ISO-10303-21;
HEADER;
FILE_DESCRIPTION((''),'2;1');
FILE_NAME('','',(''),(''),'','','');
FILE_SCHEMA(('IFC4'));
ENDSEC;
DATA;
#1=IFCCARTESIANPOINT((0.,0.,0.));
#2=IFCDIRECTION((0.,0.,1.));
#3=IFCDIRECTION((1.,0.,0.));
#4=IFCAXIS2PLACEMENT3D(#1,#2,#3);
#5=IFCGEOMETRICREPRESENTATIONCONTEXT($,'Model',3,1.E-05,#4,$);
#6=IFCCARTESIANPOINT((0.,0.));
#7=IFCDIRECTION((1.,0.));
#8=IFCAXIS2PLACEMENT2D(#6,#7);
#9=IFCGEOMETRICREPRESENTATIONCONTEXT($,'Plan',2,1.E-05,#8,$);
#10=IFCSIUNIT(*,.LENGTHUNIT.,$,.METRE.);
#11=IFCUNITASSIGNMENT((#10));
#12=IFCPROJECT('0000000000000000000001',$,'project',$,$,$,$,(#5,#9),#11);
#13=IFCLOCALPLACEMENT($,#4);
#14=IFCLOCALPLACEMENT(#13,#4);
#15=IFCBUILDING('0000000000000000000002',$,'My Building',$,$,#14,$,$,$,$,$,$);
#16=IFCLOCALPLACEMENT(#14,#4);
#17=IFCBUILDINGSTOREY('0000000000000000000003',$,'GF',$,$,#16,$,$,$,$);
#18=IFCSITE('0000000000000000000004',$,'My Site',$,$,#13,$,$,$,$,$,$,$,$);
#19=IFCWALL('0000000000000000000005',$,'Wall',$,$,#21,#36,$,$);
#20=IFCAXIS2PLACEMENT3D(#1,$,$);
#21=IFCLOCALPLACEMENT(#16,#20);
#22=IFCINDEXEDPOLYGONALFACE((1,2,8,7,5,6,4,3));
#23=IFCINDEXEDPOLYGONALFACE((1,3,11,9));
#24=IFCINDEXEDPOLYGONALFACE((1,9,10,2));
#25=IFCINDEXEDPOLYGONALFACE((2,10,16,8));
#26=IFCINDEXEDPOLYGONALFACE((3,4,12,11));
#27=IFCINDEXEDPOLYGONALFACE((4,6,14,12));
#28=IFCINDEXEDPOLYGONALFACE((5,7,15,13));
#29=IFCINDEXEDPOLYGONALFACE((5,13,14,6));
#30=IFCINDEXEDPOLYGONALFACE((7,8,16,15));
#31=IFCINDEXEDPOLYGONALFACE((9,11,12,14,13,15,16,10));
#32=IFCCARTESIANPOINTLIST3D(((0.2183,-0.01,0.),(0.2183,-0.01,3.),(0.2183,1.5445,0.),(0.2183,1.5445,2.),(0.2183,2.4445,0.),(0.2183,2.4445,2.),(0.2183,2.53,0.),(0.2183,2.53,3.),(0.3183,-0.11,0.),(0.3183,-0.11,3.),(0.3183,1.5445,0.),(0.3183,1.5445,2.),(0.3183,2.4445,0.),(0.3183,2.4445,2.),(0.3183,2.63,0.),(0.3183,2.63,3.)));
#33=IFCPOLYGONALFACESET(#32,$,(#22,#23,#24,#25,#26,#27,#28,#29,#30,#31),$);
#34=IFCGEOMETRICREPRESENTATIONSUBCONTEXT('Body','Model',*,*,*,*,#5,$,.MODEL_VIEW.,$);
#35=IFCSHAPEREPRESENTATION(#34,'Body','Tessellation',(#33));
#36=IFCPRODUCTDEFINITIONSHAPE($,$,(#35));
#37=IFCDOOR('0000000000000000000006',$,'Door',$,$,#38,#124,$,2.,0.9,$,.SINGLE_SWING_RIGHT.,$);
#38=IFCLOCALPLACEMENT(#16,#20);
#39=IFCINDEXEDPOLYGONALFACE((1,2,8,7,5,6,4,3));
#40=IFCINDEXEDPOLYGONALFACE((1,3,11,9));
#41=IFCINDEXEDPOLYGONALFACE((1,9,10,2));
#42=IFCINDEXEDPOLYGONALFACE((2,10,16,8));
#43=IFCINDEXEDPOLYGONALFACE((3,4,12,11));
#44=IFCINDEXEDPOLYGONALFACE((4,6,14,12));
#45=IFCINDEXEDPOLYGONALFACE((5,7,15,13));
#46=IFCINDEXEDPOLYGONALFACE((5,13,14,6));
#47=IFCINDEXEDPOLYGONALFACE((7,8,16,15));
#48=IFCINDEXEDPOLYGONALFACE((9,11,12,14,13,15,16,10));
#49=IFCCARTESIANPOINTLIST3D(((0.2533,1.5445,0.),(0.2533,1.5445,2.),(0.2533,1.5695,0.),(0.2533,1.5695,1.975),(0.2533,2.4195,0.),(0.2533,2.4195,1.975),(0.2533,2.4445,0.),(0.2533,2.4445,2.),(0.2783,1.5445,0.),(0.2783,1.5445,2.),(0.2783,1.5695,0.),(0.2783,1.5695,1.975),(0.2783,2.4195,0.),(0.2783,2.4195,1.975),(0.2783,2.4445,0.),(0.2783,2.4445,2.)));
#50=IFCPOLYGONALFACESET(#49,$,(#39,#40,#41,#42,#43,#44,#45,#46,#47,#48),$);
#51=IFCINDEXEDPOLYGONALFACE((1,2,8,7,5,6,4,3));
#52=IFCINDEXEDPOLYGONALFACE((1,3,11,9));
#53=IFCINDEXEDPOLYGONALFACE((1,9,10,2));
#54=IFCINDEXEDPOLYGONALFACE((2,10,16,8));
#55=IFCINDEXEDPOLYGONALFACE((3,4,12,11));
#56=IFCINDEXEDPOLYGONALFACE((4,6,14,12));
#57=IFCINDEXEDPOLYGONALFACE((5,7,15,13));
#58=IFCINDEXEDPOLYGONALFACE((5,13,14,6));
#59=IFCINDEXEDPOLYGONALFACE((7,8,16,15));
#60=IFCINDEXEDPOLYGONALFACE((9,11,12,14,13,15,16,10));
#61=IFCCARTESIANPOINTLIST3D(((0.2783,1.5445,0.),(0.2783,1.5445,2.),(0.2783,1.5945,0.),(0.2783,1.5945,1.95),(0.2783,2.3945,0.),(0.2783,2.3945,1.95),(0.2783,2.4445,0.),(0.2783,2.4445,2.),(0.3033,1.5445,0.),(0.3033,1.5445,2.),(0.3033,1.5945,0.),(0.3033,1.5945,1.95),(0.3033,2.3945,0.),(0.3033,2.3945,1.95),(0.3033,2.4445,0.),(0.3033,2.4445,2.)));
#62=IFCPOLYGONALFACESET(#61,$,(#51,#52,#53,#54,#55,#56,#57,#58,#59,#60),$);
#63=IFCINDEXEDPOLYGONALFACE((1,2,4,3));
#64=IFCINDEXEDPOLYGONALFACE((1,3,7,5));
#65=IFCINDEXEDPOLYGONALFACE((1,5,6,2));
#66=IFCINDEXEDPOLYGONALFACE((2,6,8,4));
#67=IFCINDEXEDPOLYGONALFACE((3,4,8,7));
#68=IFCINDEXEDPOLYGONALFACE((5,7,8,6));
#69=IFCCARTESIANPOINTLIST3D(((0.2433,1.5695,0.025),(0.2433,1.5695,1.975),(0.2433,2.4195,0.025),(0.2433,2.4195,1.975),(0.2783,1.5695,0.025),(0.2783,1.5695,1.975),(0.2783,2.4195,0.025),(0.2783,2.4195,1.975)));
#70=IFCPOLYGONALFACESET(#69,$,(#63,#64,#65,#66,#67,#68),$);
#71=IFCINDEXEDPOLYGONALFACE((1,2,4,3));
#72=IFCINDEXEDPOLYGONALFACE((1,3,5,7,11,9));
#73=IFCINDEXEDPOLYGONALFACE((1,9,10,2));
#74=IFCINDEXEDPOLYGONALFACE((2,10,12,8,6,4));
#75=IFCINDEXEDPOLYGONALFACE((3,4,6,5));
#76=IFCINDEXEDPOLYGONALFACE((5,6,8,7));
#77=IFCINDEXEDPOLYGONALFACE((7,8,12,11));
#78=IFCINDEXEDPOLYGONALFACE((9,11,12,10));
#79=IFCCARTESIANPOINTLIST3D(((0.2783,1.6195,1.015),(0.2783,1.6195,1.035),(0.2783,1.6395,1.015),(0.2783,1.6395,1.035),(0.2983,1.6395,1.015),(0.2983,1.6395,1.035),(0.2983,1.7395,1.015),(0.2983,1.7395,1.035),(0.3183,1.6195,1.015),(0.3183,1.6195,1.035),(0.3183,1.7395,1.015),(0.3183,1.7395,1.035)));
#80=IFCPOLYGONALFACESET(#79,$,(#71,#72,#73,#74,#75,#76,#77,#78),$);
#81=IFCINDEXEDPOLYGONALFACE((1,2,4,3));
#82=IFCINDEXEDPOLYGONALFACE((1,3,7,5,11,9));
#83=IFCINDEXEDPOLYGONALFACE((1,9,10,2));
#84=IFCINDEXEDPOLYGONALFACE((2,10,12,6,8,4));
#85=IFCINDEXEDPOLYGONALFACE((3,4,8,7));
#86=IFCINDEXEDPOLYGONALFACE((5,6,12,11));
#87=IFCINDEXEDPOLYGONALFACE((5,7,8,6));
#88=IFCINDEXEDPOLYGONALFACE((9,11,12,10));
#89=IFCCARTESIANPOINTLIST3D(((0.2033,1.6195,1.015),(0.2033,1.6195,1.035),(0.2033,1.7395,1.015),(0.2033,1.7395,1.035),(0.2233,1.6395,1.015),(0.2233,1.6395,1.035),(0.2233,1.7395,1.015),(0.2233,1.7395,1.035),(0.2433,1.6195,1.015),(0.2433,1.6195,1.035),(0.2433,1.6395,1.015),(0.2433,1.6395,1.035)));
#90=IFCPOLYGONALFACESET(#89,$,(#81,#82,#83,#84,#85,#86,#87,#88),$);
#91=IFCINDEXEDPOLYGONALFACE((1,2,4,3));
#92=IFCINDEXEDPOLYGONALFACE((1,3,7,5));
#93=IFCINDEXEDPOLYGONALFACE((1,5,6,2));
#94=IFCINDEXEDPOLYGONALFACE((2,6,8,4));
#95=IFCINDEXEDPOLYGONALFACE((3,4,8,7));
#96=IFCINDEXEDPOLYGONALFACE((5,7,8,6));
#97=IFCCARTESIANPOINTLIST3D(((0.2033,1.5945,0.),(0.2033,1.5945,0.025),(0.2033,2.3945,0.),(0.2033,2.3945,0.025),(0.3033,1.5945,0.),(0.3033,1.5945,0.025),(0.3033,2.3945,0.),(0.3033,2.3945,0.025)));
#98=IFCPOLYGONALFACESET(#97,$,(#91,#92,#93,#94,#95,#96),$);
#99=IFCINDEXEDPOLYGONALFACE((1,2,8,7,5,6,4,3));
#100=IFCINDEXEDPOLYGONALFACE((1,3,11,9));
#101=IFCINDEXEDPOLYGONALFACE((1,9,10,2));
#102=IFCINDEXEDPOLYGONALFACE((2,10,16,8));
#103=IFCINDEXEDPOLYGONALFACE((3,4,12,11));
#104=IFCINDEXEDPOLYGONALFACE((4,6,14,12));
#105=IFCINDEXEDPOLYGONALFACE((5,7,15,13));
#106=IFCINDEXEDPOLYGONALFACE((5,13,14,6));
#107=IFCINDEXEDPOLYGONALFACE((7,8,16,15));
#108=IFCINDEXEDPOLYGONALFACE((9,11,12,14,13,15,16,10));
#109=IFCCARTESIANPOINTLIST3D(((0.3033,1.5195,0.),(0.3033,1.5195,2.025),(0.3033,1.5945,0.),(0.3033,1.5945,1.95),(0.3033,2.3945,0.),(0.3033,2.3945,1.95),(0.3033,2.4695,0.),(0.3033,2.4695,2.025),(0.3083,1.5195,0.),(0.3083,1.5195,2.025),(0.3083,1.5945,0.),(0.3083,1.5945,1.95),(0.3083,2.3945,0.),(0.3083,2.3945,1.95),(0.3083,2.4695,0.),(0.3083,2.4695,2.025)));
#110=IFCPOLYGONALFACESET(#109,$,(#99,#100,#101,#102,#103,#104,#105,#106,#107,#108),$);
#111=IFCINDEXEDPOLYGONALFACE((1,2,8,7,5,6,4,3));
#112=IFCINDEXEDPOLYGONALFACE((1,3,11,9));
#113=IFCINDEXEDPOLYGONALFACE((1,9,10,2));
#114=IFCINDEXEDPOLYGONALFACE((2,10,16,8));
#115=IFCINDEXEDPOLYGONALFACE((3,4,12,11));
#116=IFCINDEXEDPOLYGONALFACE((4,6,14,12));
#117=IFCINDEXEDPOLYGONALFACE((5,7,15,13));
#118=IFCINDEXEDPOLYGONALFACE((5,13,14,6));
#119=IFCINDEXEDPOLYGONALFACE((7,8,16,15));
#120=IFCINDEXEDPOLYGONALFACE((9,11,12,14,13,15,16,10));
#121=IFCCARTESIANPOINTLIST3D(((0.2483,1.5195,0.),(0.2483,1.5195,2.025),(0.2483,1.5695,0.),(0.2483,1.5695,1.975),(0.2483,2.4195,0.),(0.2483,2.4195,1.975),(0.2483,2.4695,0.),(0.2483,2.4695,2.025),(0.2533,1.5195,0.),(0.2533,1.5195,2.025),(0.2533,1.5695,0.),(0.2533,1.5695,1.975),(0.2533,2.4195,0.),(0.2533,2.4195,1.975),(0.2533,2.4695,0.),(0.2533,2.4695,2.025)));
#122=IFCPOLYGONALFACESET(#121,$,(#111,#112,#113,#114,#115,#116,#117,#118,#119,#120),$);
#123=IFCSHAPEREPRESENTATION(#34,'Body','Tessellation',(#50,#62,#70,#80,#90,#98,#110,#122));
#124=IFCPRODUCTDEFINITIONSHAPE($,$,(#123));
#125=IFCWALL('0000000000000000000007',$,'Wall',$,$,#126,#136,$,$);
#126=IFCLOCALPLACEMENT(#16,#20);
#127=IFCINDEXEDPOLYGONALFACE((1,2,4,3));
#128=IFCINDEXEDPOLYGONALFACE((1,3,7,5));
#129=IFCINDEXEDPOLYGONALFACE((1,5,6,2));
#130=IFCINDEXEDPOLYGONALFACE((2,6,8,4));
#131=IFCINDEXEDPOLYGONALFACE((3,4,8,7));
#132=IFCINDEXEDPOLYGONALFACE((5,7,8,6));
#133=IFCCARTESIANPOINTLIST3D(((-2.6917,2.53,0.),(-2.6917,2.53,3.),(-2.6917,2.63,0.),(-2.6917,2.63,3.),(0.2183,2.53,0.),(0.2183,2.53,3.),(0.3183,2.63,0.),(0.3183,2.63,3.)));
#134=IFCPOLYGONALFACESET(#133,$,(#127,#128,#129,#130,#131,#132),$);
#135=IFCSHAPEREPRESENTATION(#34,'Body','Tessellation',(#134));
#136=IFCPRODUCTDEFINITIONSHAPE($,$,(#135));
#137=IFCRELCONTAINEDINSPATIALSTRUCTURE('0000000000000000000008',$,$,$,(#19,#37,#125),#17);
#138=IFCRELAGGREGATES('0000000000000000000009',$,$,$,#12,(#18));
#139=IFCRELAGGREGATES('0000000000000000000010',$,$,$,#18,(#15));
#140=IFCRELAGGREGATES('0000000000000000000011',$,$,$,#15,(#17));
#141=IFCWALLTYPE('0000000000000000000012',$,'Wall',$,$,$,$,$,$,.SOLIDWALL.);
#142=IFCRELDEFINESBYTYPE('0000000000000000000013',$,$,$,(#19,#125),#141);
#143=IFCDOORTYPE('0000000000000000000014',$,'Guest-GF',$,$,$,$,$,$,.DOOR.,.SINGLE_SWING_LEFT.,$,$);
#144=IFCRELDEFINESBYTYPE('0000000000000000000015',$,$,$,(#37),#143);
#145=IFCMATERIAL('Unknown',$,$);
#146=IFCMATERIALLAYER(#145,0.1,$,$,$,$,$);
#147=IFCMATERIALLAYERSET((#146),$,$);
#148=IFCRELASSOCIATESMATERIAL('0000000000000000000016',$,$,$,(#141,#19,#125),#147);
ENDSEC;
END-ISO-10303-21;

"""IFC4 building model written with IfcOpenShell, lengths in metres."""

from ifc_helpers import new_model, entity, si_unit, frame, origin_with_axes, origin_2d_with_axis, place, context, subcontext, project, spatial, line, indexed_curve, outline, extrude, shape, source, transform, mapped, material, layer, layer_set, layer_usage, type_object, type_shapes, element, fill, save


model = new_model("IFC4")

# Units and contexts
model_context_1 = context("Model", 3, precision=1e-05, world=origin_with_axes())
plan_context = context("Plan", 2, precision=1e-05, world=origin_2d_with_axis())
body_context_1 = subcontext(model_context_1, "Body", "Model", "MODEL_VIEW")
body_context_2 = subcontext(plan_context, "Body", "Plan", "PLAN_VIEW")
ifc_project = project(units=[si_unit("LENGTHUNIT", "METRE")], contexts=[model_context_1, plan_context])

# Site, building, storey
site_placement = place(None, origin_with_axes())
site = spatial("IfcSite", under=ifc_project, at=site_placement, Name="My Site")
building_placement = place(site_placement, origin_with_axes())
building = spatial("IfcBuilding", under=site, at=building_placement, Name="My Building")
storey_placement = place(building_placement, origin_with_axes())
storey = spatial("IfcBuildingStorey", under=building, at=storey_placement, Name="GF")

# Shared definitions
ifc_material_1 = material(Name="Unknown")

# Shared definitions
ifc_layer_1 = layer(ifc_material_1, 0.1)
ifc_layer_set_1 = layer_set([ifc_layer_1])
wall_type = type_object("IfcWallType", Name="Wall", PredefinedType="SOLIDWALL", material=ifc_layer_set_1)

# Wall, opening, door
ifc_layer_usage_1 = layer_usage(ifc_layer_set_1, "AXIS2", "POSITIVE", 0.0)
wall_1_placement = place(storey_placement, frame((0.3183, -0.11, 0.0), z_axis=(0.0, 0.0, 1.0), x_axis=(0.0, 1.0, 0.0)))
wall_1 = element("IfcWall", 1, at=wall_1_placement, inside=storey, type_object=wall_type, material=ifc_layer_usage_1, Name="Wall", context=body_context_1, shape_type="SweptSolid", body=[
    extrude(outline(indexed_curve([(0.0, 0.0), (0.1, 0.1), (2.64, 0.1), (2.74, 0.0)], segments=[line(1, 2, 3, 4, 1)])), origin_with_axes(), (0.0, 0.0, 1.0), 3.0),
])
shared_shape_1 = source(origin_with_axes(), body_context_1, "Body", "SweptSolid", [
    extrude(outline(indexed_curve([(0.0, 0.0), (0.9, 0.0), (0.9, 2.0), (0.0, 2.0)], segments=[line(1, 2, 3, 4, 1)])), frame((0.0, -0.6, 0.0), z_axis=(0.0, -1.0, 0.0), x_axis=(1.0, 0.0, 0.0)), (0.0, 0.0, -1.0), 1.2),
])
opening_1_placement = place(wall_1_placement, frame((1.6545, 0.015, 0.0), z_axis=(0.0, 0.0, 1.0), x_axis=(1.0, 0.0, 0.0)))
opening_1 = element("IfcOpeningElement", 2, at=opening_1_placement, cuts=wall_1, PredefinedType="OPENING", context=body_context_1, shape_type="MappedRepresentation", body=[
    mapped(shared_shape_1, transform((0.0, 0.0, 0.0), x_axis=(1.0, 0.0, 0.0), y_axis=(0.0, 1.0, 0.0), z_axis=(0.0, 0.0, 1.0), scale=1.0)),
])
door_type_1 = type_object("IfcDoorType", Name="Guest-GF", OperationType="SINGLE_SWING_LEFT", PredefinedType="DOOR")
shared_shape_2 = source(origin_with_axes(), body_context_1, "Body", "SweptSolid", [
    extrude(outline(indexed_curve([(0.0, 0.0), (0.0, 2.0), (0.9, 2.0), (0.9, 0.0), (0.875, 0.0), (0.875, 1.975), (0.025, 1.975), (0.025, 0.0)], segments=[line(1, 2, 3, 4, 5, 6, 7, 8, 1)])), frame((0.0, 0.025, 0.0), z_axis=(0.0, -1.0, 0.0), x_axis=(1.0, 0.0, 0.0)), (0.0, 0.0, -1.0), 0.025),
    extrude(outline(indexed_curve([(0.0, 0.0), (0.0, 2.0), (0.9, 2.0), (0.9, 0.0), (0.85, 0.0), (0.85, 1.95), (0.05, 1.95), (0.05, 0.0)], segments=[line(1, 2, 3, 4, 5, 6, 7, 8, 1)])), frame((0.0, 0.0, 0.0), z_axis=(0.0, -1.0, 0.0), x_axis=(1.0, 0.0, 0.0)), (0.0, 0.0, -1.0), 0.025),
    extrude(outline(indexed_curve([(0.0, 0.0), (0.85, 0.0), (0.85, 0.035), (0.0, 0.035)], segments=[line(1, 2, 3, 4, 1)])), frame((0.025, 0.025, 0.025), z_axis=(0.0, 0.0, 1.0), x_axis=(1.0, 0.0, 0.0)), (0.0, 0.0, 1.0), 1.95),
    extrude(outline(indexed_curve([(0.0, 0.0), (0.0, -0.04), (0.12, -0.04), (0.12, -0.02), (0.02, -0.02), (0.02, 0.0)], segments=[line(1, 2, 3, 4, 5, 6, 1)])), frame((0.075, 0.025, 1.015), z_axis=(0.0, 0.0, 1.0), x_axis=(1.0, 0.0, 0.0)), (0.0, 0.0, 1.0), 0.02),
    extrude(outline(indexed_curve([(0.0, 0.0), (0.0, 0.04), (0.12, 0.04), (0.12, 0.02), (0.02, 0.02), (0.02, 0.0)], segments=[line(1, 2, 3, 4, 5, 6, 1)])), frame((0.075, 0.06, 1.015), z_axis=(0.0, 0.0, 1.0), x_axis=(1.0, 0.0, 0.0)), (0.0, 0.0, 1.0), 0.02),
    extrude(outline(indexed_curve([(0.0, 0.0), (0.8, 0.0), (0.8, 0.1), (0.0, 0.1)], segments=[line(1, 2, 3, 4, 1)])), frame((0.05, 0.0, 0.0), z_axis=(0.0, 0.0, 1.0), x_axis=(1.0, 0.0, 0.0)), (0.0, 0.0, 1.0), 0.025),
    extrude(outline(indexed_curve([(0.0, 0.0), (0.0, 2.025), (0.95, 2.025), (0.95, 0.0), (0.875, 0.0), (0.875, 1.95), (0.075, 1.95), (0.075, 0.0)], segments=[line(1, 2, 3, 4, 5, 6, 7, 8, 1)])), frame((-0.025, -0.005, 0.0), z_axis=(0.0, -1.0, 0.0), x_axis=(1.0, 0.0, 0.0)), (0.0, 0.0, -1.0), 0.005),
    extrude(outline(indexed_curve([(0.0, 0.0), (0.0, 2.025), (0.95, 2.025), (0.95, 0.0), (0.9, 0.0), (0.9, 1.975), (0.05, 1.975), (0.05, 0.0)], segments=[line(1, 2, 3, 4, 5, 6, 7, 8, 1)])), frame((-0.025, 0.05, 0.0), z_axis=(0.0, -1.0, 0.0), x_axis=(1.0, 0.0, 0.0)), (0.0, 0.0, -1.0), 0.005),
])
shared_shape_3 = source(origin_with_axes(), body_context_2, "Body", "Curve2D", [
    entity("IfcIndexedPolyCurve", entity("IfcCartesianPointList2D", [[0.0, 0.0], [0.0, 0.05], [0.025, 0.05], [0.025, 0.025], [0.05, 0.025], [0.05, 0.0]]), [entity("IfcLineIndex", [1, 2, 3, 4, 5, 6, 1])]),
    entity("IfcIndexedPolyCurve", entity("IfcCartesianPointList2D", [[0.9, 0.0], [0.9, 0.05], [0.875, 0.05], [0.875, 0.025], [0.85, 0.025], [0.85, 0.0]]), [entity("IfcLineIndex", [1, 2, 3, 4, 5, 6, 1])]),
    entity("IfcTrimmedCurve", entity("IfcEllipse", entity("IfcAxis2Placement2D", entity("IfcCartesianPoint", [0.84, 0.05]), entity("IfcDirection", [1.0, 0.0])), 0.815, 0.85), [entity("IfcCartesianPoint", [0.84, 0.9])], [entity("IfcCartesianPoint", [0.025, 0.05])], True, "CARTESIAN"),
    entity("IfcIndexedPolyCurve", entity("IfcCartesianPointList2D", [[0.875, 0.05], [0.84, 0.05], [0.84, 0.9], [0.875, 0.9]]), [entity("IfcLineIndex", [1, 2, 3, 4, 1])]),
])
type_shapes(door_type_1, [shared_shape_2, shared_shape_3])
door_1_placement = place(opening_1_placement, frame((0.0, 0.0, 0.0), z_axis=(0.0, 0.0, 1.0), x_axis=(1.0, 0.0, 0.0)))
door_1 = element("IfcDoor", 3, at=door_1_placement, inside=storey, type_object=door_type_1, Name="Door", OperationType="SINGLE_SWING_RIGHT", OverallHeight=2.0, OverallWidth=0.9, shapes=[
    shape(body_context_1, "Body", "MappedRepresentation", [mapped(shared_shape_2, transform((0.0, 0.0, 0.0), x_axis=(1.0, 0.0, 0.0), y_axis=(0.0, 1.0, 0.0), z_axis=(0.0, 0.0, 1.0), scale=1.0))]),
    shape(body_context_2, "Body", "MappedRepresentation", [mapped(shared_shape_3, transform((0.0, 0.0, 0.0), x_axis=(1.0, 0.0, 0.0), y_axis=(0.0, 1.0, 0.0), z_axis=(0.0, 0.0, 1.0), scale=1.0))]),
])
fill(opening_1, door_1)

# Wall
ifc_layer_usage_2 = layer_usage(ifc_layer_set_1, "AXIS2", "POSITIVE", 0.0)
wall_2_placement = place(storey_placement, frame((0.3183, 2.63, 0.0), z_axis=(0.0, 0.0, 1.0), x_axis=(-1.0, 0.0, 0.0)))
element("IfcWall", 4, at=wall_2_placement, inside=storey, type_object=wall_type, material=ifc_layer_usage_2, Name="Wall", context=body_context_1, shape_type="SweptSolid", body=[
    extrude(outline(indexed_curve([(0.0, 0.0), (0.1, 0.1), (3.01, 0.1), (3.01, 0.0)], segments=[line(1, 2, 3, 4, 1)])), origin_with_axes(), (0.0, 0.0, 1.0), 3.0),
])

save(model, "model.ifc")
